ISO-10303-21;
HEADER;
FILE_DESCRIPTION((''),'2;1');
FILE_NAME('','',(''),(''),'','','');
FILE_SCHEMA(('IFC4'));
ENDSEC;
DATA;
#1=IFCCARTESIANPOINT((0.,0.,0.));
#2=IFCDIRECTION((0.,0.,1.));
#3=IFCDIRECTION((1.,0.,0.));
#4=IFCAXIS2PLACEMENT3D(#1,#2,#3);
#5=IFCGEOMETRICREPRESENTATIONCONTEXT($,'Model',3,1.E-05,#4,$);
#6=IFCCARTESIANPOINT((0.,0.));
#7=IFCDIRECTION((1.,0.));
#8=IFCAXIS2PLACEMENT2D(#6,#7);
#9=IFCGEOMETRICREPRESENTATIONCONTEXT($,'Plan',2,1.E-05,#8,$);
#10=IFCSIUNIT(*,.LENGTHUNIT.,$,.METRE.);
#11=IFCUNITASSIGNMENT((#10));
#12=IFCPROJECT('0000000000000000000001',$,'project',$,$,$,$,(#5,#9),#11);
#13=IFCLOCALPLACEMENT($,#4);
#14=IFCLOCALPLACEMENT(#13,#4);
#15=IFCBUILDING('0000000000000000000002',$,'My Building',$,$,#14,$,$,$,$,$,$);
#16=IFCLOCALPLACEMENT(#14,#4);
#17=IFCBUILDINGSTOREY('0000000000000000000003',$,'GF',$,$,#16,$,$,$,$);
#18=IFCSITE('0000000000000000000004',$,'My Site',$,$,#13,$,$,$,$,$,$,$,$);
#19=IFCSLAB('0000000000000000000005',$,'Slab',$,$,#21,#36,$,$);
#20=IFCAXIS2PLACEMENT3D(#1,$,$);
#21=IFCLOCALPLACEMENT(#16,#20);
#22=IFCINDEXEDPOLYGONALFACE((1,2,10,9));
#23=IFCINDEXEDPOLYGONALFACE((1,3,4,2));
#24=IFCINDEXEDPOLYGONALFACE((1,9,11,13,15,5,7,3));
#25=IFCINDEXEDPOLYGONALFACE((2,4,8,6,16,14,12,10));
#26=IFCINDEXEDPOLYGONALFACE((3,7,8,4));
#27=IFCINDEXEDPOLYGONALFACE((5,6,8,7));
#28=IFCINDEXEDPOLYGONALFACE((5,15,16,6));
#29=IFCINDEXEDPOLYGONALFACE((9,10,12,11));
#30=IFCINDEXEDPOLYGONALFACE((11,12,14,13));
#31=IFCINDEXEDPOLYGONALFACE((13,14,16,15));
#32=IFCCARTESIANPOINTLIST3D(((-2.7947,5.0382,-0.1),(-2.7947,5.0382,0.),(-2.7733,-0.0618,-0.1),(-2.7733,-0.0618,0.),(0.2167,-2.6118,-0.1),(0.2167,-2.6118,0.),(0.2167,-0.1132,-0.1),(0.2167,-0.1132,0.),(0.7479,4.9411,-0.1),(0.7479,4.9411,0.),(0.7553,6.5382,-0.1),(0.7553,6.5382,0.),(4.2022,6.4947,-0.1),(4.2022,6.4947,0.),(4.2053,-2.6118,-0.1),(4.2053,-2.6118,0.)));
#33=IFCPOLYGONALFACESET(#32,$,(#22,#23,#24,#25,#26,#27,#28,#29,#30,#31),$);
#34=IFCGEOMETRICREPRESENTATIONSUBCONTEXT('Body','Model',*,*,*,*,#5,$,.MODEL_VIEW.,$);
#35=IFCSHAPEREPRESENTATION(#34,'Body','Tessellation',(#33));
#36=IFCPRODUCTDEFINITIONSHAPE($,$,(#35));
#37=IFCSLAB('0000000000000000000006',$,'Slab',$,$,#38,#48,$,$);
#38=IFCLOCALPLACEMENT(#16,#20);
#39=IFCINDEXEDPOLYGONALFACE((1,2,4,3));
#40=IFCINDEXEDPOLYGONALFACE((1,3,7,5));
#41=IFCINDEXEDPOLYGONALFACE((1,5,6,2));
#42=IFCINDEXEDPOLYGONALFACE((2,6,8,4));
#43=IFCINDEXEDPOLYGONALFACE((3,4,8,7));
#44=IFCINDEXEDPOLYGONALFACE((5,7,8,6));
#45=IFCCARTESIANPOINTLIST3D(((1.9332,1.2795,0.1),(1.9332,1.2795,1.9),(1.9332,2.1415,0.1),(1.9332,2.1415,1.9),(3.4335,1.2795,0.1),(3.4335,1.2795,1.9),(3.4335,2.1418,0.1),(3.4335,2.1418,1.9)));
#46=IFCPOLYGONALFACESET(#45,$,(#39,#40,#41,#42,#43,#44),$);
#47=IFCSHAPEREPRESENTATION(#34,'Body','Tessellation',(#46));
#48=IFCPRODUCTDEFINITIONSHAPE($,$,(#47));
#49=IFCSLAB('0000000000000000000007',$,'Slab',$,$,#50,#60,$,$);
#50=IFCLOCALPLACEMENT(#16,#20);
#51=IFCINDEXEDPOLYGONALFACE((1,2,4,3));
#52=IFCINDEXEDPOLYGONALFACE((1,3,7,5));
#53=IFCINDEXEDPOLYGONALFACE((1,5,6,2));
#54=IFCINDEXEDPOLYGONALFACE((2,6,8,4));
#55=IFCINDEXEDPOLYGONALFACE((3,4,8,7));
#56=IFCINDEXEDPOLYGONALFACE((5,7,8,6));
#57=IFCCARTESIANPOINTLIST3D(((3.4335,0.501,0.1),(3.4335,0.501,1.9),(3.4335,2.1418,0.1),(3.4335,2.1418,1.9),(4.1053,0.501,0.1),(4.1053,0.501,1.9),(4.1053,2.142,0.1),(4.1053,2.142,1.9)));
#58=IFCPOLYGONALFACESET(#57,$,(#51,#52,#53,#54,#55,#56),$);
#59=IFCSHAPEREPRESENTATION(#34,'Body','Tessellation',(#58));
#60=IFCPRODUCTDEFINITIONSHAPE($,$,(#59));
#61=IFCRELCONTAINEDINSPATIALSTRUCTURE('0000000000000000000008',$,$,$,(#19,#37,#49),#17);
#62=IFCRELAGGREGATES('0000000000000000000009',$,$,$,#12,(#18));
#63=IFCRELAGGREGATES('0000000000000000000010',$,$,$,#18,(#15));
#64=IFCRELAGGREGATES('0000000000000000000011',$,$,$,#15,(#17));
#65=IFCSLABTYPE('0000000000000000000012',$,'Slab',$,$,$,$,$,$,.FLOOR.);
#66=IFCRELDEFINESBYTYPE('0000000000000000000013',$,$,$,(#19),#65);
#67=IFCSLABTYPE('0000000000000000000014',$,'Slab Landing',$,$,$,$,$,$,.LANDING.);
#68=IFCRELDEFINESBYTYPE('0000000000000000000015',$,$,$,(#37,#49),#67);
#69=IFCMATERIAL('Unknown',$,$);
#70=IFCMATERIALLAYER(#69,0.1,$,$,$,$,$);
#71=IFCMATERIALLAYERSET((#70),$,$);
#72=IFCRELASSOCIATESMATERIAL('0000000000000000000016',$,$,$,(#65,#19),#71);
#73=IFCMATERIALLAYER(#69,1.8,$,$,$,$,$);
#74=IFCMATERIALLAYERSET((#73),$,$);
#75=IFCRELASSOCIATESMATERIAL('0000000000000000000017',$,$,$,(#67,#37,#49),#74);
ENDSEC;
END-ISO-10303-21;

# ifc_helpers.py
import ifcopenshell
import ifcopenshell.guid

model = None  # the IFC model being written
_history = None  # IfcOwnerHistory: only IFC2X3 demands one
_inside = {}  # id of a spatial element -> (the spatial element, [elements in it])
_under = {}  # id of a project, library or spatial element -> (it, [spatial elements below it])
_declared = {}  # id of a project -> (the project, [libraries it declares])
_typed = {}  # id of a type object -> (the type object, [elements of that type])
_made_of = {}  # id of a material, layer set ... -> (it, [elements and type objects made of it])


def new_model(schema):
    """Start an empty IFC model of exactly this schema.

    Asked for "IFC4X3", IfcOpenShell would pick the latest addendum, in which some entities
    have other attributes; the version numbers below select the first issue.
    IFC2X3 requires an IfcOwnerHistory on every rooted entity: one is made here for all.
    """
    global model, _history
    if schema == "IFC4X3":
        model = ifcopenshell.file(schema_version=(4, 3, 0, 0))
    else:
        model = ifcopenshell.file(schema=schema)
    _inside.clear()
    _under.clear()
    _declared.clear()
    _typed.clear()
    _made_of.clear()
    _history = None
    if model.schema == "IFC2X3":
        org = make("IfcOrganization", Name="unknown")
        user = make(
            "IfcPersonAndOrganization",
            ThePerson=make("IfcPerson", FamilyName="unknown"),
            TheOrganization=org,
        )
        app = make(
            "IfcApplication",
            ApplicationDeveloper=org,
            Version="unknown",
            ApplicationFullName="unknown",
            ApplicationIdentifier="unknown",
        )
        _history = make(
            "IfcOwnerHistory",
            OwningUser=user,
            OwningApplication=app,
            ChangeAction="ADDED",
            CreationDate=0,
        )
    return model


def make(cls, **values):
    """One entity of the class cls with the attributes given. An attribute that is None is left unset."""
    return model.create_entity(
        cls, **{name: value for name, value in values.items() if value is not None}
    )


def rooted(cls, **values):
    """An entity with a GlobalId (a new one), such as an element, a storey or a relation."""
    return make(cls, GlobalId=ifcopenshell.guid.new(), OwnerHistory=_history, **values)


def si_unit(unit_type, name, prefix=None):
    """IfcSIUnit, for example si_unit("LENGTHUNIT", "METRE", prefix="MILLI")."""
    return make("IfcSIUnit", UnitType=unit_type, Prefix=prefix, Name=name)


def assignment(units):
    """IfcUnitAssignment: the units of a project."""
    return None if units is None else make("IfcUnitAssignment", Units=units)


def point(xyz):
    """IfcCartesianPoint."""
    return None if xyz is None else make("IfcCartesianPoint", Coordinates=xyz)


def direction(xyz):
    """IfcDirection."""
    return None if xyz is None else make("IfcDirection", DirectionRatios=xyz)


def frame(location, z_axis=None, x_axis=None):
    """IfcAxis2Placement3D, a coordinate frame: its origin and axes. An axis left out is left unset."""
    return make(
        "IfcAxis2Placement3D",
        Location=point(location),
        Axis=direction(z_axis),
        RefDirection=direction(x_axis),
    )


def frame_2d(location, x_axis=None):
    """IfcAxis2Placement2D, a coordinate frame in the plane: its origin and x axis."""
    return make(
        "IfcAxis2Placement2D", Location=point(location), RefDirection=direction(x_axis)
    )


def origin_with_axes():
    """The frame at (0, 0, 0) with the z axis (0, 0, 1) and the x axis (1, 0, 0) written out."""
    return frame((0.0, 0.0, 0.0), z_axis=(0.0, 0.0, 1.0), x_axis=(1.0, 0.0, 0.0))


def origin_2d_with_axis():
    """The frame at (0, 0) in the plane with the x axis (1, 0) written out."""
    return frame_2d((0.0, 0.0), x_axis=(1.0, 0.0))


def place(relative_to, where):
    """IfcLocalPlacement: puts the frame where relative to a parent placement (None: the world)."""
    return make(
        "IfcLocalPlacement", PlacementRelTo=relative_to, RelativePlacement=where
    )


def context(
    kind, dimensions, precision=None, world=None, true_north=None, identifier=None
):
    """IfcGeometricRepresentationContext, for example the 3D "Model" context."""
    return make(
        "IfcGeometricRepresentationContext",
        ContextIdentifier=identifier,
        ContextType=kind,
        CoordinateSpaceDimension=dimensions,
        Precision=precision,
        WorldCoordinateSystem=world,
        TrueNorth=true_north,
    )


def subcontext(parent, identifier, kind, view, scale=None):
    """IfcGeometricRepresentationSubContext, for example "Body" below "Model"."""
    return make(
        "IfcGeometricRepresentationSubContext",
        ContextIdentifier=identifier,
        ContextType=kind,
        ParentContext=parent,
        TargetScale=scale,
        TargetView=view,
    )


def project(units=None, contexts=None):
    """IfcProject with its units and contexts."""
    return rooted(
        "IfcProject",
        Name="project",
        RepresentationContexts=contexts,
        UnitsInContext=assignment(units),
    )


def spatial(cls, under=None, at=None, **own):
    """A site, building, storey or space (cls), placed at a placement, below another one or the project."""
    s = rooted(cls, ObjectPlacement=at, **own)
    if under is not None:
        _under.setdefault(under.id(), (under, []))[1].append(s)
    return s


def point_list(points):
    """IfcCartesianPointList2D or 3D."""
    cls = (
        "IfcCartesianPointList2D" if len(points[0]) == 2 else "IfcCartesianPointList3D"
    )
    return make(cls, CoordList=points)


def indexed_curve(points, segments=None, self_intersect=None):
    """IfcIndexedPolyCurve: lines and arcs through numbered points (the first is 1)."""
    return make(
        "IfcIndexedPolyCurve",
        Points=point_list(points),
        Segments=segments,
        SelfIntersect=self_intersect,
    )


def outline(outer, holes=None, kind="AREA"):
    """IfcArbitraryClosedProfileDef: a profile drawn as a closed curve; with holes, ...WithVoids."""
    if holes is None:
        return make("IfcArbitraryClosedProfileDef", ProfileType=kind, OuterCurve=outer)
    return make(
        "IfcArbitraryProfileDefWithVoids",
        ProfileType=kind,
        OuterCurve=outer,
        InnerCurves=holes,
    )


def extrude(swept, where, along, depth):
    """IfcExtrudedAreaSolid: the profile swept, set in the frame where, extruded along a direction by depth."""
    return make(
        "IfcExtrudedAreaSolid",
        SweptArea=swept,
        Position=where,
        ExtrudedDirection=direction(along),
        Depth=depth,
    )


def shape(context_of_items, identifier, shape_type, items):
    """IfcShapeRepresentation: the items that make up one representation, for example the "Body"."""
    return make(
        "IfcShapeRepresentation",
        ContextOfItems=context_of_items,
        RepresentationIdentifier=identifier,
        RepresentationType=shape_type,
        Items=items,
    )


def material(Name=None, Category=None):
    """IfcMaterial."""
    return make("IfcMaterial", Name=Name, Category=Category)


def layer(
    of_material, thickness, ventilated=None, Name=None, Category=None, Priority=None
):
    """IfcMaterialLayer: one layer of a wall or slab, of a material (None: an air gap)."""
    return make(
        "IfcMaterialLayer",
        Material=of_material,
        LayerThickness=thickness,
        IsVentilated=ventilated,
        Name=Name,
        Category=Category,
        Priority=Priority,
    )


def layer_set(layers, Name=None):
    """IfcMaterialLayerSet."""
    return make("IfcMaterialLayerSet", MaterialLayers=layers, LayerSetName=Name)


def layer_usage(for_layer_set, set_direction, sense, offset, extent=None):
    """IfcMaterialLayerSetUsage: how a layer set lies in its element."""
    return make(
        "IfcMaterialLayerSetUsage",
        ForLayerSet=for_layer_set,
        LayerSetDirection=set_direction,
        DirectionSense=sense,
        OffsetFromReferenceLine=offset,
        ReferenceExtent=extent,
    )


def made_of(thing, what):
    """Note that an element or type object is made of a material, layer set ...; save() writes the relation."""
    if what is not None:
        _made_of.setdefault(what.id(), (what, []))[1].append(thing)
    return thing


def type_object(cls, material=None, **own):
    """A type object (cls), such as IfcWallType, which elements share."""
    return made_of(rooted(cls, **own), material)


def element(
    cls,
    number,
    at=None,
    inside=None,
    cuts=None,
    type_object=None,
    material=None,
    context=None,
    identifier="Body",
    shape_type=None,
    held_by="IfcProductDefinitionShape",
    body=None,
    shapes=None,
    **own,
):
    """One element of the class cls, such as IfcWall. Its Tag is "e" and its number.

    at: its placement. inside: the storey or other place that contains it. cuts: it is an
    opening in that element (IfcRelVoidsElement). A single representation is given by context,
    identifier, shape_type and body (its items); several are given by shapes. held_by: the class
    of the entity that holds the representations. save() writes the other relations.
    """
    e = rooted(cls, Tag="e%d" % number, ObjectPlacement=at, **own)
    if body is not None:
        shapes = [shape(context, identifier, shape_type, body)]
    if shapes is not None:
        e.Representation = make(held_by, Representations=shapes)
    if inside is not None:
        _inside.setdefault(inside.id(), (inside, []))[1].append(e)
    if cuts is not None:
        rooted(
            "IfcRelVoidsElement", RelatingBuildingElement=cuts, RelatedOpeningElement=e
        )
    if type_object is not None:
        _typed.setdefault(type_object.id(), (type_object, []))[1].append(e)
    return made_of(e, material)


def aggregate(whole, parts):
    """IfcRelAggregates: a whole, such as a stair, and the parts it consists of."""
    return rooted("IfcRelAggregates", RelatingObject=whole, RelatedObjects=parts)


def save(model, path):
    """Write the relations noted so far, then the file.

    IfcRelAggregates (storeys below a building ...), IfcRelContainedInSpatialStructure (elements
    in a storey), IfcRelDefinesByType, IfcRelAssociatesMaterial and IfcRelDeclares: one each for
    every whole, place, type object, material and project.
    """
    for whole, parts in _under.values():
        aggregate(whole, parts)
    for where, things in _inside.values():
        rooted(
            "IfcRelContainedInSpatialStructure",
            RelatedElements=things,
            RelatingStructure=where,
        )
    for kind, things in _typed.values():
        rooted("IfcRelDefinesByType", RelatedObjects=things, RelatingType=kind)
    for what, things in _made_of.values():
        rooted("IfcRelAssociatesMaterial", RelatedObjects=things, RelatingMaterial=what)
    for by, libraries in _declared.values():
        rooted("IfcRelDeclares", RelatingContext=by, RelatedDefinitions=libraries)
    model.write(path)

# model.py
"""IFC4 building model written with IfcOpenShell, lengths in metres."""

from ifc_helpers import new_model, si_unit, frame, origin_with_axes, origin_2d_with_axis, place, context, subcontext, project, spatial, indexed_curve, outline, extrude, material, layer, layer_set, layer_usage, type_object, element, save


model = new_model("IFC4")

# Units and contexts
model_context = context("Model", 3, precision=1e-05, world=origin_with_axes())
plan_context = context("Plan", 2, precision=1e-05, world=origin_2d_with_axis())
body_context_1 = subcontext(model_context, "Body", "Model", "MODEL_VIEW")
ifc_project = project(units=[si_unit("LENGTHUNIT", "METRE")], contexts=[model_context, plan_context])

# Site, building, storey
site_placement = place(None, origin_with_axes())
site = spatial("IfcSite", under=ifc_project, at=site_placement, Name="My Site")
building_placement = place(site_placement, origin_with_axes())
building = spatial("IfcBuilding", under=site, at=building_placement, Name="My Building")
storey_placement = place(building_placement, origin_with_axes())
storey = spatial("IfcBuildingStorey", under=building, at=storey_placement, Name="GF")

# Slabs
ifc_material_1 = material(Name="Unknown")
ifc_layer_1 = layer(ifc_material_1, 0.1)
ifc_layer_set_1 = layer_set([ifc_layer_1])
ifc_layer_usage_1 = layer_usage(ifc_layer_set_1, "AXIS3", "POSITIVE", -0.1)
slab_type_1 = type_object("IfcSlabType", Name="Slab", PredefinedType="FLOOR", material=ifc_layer_set_1)
slab_1_placement = place(storey_placement, frame((4.2022, 6.4947, 0.0), z_axis=(0.0, 0.0, 1.0), x_axis=(1.0, 0.0, 0.0)))
element("IfcSlab", 1, at=slab_1_placement, inside=storey, type_object=slab_type_1, material=ifc_layer_usage_1, Name="Slab", context=body_context_1, shape_type="SweptSolid", body=[
    extrude(outline(indexed_curve([(0.0, 0.0), (-3.4469, 0.0435), (-3.4543, -1.5535), (-6.9969, -1.4565), (-6.9755, -6.5565), (-3.9855, -6.6078), (-3.9855, -9.1065), (0.0031, -9.1065), (0.0, 0.0)])), frame((0.0, 0.0, -0.1), z_axis=(0.0, 0.0, 1.0), x_axis=(1.0, 0.0, 0.0)), (0.0, 0.0, 1.0), 0.1),
])
ifc_layer_2 = layer(ifc_material_1, 1.8)
ifc_layer_set_2 = layer_set([ifc_layer_2])
ifc_layer_usage_2 = layer_usage(ifc_layer_set_2, "AXIS3", "POSITIVE", -1.8)
slab_type_2 = type_object("IfcSlabType", Name="Slab Landing", PredefinedType="LANDING", material=ifc_layer_set_2)
slab_2_placement = place(storey_placement, frame((3.4335, 2.1418, 1.9), z_axis=(0.0, 0.0, 1.0), x_axis=(1.0, 0.0, 0.0)))
element("IfcSlab", 2, at=slab_2_placement, inside=storey, type_object=slab_type_2, material=ifc_layer_usage_2, Name="Slab", context=body_context_1, shape_type="SweptSolid", body=[
    extrude(outline(indexed_curve([(0.0, 0.0), (0.0, -0.8624), (-1.5003, -0.8624), (-1.5003, -0.0004), (0.0, 0.0)])), frame((0.0, 0.0, -1.8), z_axis=(0.0, 0.0, 1.0), x_axis=(1.0, 0.0, 0.0)), (0.0, 0.0, 1.0), 1.8),
])
ifc_layer_usage_3 = layer_usage(ifc_layer_set_2, "AXIS3", "POSITIVE", -1.8)
slab_3_placement = place(storey_placement, frame((3.4335, 2.1418, 1.9), z_axis=(0.0, 0.0, 1.0), x_axis=(1.0, 0.0, 0.0)))
element("IfcSlab", 3, at=slab_3_placement, inside=storey, type_object=slab_type_2, material=ifc_layer_usage_3, Name="Slab", context=body_context_1, shape_type="SweptSolid", body=[
    extrude(outline(indexed_curve([(0.0, 0.0), (0.0, -1.6408), (0.6719, -1.6408), (0.6719, 0.0002), (0.0, 0.0)])), frame((0.0, 0.0, -1.8), z_axis=(0.0, 0.0, 1.0), x_axis=(1.0, 0.0, 0.0)), (0.0, 0.0, 1.0), 1.8),
])

save(model, "model.ifc")
